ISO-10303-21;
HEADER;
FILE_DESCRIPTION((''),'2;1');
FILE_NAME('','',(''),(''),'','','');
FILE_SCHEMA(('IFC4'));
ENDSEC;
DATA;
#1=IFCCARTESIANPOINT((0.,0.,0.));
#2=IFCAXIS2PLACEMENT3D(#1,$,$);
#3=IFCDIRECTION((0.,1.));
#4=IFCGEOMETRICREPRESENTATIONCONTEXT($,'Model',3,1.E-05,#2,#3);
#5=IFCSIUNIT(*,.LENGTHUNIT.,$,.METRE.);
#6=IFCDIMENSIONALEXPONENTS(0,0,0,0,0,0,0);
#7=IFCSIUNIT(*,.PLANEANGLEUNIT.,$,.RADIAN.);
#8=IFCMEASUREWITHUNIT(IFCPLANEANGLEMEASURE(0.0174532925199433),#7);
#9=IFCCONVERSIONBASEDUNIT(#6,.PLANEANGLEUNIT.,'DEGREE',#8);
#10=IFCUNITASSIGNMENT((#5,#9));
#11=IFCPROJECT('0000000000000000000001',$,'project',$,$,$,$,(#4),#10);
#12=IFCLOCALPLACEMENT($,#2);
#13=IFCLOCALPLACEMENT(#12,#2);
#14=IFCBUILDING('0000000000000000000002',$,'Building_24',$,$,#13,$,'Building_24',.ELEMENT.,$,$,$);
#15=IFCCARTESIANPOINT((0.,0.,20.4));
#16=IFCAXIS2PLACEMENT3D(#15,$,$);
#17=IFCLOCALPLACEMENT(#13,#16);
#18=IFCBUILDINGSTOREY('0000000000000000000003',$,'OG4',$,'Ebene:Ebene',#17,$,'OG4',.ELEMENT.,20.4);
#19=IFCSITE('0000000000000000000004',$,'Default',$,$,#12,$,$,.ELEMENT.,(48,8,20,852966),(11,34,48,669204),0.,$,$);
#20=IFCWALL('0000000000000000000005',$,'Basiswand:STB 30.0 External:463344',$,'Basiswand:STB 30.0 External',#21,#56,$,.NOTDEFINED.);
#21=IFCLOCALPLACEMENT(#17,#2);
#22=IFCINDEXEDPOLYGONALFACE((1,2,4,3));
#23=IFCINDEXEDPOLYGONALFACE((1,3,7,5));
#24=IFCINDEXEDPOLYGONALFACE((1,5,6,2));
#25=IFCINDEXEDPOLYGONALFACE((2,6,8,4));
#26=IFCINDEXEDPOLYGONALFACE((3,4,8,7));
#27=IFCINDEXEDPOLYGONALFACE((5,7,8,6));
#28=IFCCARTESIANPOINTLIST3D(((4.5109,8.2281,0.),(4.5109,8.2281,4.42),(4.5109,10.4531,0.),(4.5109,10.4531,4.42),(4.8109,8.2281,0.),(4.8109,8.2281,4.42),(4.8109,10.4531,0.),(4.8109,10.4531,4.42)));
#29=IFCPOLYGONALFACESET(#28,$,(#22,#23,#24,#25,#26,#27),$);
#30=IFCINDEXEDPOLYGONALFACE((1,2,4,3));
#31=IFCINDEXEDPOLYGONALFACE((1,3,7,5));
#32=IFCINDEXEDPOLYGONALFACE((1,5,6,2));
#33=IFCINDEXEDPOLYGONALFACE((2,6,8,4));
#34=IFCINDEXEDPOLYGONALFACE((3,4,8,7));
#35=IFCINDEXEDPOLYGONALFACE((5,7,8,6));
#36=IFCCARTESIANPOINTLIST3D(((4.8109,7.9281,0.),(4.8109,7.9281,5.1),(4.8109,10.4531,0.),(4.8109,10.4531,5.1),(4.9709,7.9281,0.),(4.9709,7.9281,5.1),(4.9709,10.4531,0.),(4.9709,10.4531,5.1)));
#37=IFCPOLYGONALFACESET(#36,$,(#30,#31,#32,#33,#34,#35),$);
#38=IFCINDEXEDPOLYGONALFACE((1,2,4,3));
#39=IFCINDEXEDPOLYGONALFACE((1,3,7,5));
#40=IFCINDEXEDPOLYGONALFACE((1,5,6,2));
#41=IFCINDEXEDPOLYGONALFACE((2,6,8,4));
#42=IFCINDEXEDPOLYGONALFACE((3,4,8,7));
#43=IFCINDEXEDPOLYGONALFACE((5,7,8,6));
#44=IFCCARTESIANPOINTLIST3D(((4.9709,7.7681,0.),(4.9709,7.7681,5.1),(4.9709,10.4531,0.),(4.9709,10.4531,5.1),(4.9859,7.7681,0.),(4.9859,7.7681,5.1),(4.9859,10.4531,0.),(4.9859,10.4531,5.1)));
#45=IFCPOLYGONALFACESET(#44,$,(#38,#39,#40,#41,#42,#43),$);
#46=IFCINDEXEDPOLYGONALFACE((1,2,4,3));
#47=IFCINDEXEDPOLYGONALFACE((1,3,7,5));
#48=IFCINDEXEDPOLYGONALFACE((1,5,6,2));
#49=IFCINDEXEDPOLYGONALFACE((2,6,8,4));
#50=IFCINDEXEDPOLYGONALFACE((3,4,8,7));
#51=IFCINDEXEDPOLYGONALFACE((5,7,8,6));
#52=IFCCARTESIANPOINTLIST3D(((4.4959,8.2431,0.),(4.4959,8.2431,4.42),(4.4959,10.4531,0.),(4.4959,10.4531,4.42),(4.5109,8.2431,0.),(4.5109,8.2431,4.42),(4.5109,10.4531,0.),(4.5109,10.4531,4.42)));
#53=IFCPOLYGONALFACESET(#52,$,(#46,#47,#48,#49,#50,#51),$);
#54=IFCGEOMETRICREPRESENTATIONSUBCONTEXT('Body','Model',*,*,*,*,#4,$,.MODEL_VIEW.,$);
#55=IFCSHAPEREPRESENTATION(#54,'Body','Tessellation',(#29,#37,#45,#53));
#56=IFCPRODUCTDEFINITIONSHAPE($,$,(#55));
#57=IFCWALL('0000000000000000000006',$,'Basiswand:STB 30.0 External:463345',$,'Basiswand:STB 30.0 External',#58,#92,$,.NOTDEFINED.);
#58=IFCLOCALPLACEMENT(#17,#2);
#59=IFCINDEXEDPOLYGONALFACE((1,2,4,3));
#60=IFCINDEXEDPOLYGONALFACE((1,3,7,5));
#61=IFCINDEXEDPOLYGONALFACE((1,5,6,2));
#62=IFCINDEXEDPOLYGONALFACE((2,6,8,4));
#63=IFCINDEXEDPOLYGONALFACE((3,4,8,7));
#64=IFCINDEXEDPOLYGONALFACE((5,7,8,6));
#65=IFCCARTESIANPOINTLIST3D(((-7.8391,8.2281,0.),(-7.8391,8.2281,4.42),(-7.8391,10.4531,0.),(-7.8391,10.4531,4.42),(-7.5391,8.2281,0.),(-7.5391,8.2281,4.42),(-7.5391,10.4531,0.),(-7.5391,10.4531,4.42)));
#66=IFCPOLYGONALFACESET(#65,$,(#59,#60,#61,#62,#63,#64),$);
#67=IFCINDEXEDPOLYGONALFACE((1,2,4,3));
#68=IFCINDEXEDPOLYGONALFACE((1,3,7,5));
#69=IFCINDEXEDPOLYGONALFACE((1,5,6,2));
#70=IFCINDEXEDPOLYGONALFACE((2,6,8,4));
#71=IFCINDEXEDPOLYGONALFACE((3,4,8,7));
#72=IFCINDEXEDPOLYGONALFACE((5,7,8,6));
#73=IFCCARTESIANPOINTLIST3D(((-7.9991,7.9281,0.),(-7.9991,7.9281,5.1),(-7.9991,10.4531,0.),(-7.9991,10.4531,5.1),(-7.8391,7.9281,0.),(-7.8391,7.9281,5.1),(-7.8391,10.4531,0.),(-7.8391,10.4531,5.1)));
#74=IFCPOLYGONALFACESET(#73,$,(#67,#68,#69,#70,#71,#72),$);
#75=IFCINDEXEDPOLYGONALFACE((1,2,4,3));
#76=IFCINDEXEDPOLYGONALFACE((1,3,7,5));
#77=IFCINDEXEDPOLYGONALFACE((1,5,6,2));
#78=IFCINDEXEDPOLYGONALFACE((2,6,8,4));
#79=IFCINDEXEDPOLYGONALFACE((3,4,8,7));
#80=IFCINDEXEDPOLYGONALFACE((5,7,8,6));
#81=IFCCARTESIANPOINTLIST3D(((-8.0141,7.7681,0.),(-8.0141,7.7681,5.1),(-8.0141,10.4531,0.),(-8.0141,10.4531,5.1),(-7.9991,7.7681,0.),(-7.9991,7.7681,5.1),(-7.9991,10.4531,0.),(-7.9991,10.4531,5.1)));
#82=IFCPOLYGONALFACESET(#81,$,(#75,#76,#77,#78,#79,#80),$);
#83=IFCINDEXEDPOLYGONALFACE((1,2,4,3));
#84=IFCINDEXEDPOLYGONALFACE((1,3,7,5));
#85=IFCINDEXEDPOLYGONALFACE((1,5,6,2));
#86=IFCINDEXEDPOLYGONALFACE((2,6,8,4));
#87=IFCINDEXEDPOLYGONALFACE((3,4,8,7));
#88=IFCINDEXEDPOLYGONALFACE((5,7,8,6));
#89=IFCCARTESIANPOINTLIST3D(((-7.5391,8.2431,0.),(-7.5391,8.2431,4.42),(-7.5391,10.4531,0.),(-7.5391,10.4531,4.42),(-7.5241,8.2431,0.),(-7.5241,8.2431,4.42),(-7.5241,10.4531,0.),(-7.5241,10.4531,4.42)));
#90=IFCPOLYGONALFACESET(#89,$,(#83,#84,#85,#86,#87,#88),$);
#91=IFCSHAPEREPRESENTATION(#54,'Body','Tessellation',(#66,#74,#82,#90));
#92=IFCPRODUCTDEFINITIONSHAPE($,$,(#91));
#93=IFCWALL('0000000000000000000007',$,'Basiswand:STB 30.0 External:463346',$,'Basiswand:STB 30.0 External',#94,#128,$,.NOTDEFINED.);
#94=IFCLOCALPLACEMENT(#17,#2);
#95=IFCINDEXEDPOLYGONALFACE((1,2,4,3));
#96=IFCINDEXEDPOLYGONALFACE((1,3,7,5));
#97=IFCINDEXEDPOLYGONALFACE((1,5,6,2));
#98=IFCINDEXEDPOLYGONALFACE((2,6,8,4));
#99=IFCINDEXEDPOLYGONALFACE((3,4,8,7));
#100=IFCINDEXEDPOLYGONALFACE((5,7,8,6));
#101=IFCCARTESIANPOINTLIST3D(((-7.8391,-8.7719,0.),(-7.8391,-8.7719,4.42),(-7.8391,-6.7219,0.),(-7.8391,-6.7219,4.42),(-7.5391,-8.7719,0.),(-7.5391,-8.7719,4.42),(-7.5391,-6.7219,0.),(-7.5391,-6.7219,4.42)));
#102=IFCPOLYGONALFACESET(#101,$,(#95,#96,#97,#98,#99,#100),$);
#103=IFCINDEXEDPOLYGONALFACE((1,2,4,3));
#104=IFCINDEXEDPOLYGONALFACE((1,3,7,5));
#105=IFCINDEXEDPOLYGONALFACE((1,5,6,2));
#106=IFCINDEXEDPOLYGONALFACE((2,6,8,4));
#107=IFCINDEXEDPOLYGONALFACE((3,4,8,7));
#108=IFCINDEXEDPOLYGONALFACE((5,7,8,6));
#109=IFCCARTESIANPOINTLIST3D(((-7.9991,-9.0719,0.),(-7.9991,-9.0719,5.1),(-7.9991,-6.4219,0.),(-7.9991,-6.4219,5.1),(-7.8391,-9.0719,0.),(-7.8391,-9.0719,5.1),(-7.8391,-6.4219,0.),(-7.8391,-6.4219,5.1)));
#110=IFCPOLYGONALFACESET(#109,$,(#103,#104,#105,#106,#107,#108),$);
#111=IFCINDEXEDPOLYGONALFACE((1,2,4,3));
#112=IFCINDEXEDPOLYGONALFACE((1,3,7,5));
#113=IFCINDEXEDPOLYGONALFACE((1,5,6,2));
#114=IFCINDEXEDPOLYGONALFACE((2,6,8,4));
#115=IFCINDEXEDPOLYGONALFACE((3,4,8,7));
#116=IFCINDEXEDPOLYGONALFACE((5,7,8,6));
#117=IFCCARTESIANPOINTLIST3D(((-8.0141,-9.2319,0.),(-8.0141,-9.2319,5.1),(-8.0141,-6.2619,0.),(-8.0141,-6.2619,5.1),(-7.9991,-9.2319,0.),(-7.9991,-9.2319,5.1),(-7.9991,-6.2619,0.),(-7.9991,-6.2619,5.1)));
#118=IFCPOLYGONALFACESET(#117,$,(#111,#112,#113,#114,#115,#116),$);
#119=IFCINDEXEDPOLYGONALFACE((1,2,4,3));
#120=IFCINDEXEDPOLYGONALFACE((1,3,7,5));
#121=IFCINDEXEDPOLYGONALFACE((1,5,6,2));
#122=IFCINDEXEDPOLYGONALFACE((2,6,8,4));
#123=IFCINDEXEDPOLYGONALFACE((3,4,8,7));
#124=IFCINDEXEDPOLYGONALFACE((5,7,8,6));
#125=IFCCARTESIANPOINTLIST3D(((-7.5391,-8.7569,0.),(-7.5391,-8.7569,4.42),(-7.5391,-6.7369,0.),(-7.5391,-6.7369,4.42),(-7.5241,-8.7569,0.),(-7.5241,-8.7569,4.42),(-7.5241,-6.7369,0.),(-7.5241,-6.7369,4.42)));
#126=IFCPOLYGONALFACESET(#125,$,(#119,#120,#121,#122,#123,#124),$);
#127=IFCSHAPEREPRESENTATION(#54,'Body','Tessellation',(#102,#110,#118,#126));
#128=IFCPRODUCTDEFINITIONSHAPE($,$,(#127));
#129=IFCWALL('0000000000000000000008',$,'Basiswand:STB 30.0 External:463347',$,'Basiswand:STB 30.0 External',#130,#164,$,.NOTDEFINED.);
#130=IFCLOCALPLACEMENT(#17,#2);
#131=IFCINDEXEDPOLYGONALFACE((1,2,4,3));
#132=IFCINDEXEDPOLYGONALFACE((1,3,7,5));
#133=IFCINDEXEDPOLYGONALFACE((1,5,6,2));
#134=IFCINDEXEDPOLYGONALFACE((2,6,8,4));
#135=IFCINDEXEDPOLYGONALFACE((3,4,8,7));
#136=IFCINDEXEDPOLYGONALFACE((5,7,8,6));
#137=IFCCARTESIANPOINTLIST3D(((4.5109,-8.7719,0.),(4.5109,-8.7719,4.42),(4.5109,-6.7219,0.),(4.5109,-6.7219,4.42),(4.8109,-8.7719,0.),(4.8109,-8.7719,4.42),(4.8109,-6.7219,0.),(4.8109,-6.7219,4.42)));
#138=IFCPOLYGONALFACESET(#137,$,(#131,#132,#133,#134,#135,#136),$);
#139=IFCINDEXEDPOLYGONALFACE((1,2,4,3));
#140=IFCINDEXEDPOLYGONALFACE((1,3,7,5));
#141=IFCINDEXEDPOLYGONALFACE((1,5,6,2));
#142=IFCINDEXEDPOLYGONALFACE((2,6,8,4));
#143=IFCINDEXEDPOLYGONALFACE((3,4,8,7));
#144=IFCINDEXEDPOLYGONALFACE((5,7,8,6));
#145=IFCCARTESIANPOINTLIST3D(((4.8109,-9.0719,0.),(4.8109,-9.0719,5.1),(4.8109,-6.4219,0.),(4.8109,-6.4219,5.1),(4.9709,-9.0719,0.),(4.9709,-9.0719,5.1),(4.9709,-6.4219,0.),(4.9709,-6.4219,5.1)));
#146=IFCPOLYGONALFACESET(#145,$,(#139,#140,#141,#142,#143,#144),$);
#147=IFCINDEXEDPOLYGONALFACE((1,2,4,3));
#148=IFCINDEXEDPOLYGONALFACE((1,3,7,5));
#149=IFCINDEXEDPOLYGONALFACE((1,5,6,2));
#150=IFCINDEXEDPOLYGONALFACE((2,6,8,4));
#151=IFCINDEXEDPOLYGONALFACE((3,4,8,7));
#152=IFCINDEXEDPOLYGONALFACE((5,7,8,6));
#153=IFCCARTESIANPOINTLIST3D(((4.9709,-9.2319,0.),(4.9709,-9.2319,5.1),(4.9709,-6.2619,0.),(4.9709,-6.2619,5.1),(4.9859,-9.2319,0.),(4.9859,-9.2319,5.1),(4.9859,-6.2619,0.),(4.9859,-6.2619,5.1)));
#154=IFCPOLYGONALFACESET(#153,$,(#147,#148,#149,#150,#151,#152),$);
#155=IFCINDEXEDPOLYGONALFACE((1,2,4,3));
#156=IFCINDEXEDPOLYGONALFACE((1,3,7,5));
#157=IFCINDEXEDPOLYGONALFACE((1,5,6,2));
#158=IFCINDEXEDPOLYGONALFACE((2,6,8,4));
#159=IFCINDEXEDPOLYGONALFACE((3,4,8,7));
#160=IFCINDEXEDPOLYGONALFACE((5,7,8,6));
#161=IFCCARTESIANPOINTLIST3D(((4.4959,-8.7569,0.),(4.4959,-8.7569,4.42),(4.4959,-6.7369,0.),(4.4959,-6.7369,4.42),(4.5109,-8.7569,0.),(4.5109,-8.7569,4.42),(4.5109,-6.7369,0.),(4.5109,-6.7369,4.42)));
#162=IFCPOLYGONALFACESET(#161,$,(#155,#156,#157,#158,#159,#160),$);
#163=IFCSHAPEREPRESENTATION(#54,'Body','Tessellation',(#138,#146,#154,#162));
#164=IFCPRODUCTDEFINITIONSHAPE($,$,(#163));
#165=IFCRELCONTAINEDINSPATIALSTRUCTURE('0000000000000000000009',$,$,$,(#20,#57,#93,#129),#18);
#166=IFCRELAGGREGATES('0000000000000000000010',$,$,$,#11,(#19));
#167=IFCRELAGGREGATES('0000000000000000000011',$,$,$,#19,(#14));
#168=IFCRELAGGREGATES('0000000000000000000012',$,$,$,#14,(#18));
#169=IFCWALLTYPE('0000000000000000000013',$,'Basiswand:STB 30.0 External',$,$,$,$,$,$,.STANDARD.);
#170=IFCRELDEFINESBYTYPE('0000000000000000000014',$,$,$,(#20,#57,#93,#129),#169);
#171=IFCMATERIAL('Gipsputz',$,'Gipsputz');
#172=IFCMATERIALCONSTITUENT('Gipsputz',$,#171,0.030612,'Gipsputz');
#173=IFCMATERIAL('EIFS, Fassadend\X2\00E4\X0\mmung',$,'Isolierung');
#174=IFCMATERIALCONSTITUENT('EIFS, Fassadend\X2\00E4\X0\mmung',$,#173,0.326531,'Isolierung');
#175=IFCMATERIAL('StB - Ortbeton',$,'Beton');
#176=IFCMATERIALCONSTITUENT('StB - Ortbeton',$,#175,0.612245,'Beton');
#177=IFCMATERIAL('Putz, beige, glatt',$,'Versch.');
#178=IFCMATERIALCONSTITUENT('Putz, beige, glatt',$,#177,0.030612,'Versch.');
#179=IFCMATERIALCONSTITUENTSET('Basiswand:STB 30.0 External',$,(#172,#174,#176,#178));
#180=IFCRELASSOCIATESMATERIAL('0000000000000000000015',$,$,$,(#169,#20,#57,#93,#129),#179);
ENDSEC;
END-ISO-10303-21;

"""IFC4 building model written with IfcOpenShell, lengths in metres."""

from ifc_helpers import new_model, entity, si_unit, converted_unit, direction, frame, origin, place, context, subcontext, project, spatial, indexed_curve, outline, extrude, material, constituent, constituent_set, type_object, element, save


model = new_model("IFC4")

# Units and contexts
model_context = context("Model", 3, precision=1e-05, world=origin(), true_north=direction((0.0, 1.0)))
body_context = subcontext(model_context, "Body", "Model", "MODEL_VIEW")
ifc_project = project(units=[si_unit("LENGTHUNIT", "METRE"), converted_unit("PLANEANGLEUNIT", "DEGREE", entity("IfcPlaneAngleMeasure", 0.0174532925199433), si_unit("PLANEANGLEUNIT", "RADIAN"), dimensions=[0, 0, 0, 0, 0, 0, 0])], contexts=[model_context])

# Site, building, storey
site_placement = place(None, origin())
site = spatial("IfcSite", under=ifc_project, at=site_placement, Name="Default", CompositionType="ELEMENT", RefLatitude=(48, 8, 20, 852966), RefLongitude=(11, 34, 48, 669204), RefElevation=0.0)
building_placement = place(site_placement, origin())
building = spatial("IfcBuilding", under=site, at=building_placement, Name="Building_24", LongName="Building_24", CompositionType="ELEMENT")
storey_placement = place(building_placement, frame((0.0, 0.0, 20.4)))
storey = spatial("IfcBuildingStorey", under=building, at=storey_placement, Name="OG4", ObjectType="Ebene:Ebene", LongName="OG4", CompositionType="ELEMENT", Elevation=20.4)

# Shared definitions
ifc_material_1 = material(Name="StB - Ortbeton", Category="Beton")

# Walls
ifc_material_2 = material(Name="Gipsputz", Category="Gipsputz")
ifc_constituent_1 = constituent(ifc_material_2, Name="Gipsputz", Category="Gipsputz", fraction=0.030612)
ifc_material_3 = material(Name="EIFS, Fassadendämmung", Category="Isolierung")
ifc_constituent_2 = constituent(ifc_material_3, Name="EIFS, Fassadendämmung", Category="Isolierung", fraction=0.326531)
ifc_constituent_3 = constituent(ifc_material_1, Name="StB - Ortbeton", Category="Beton", fraction=0.612245)
ifc_material_4 = material(Name="Putz, beige, glatt", Category="Versch.")
ifc_constituent_4 = constituent(ifc_material_4, Name="Putz, beige, glatt", Category="Versch.", fraction=0.030612)
ifc_constituent_set_1 = constituent_set(constituents=[ifc_constituent_1, ifc_constituent_2, ifc_constituent_3, ifc_constituent_4], Name="Basiswand:STB 30.0 External")
wall_type_1 = type_object("IfcWallType", Name="Basiswand:STB 30.0 External", PredefinedType="STANDARD", material=ifc_constituent_set_1)
wall_1_placement = place(storey_placement, frame((4.7409, 10.4531, 0.0), z_axis=(0.0, 0.0, 1.0), x_axis=(0.0, -1.0, 0.0)))
element("IfcWall", 1, at=wall_1_placement, inside=storey, type_object=wall_type_1, material=ifc_constituent_set_1, Name="Basiswand:STB 30.0 External:463344", ObjectType="Basiswand:STB 30.0 External", PredefinedType="NOTDEFINED", context=body_context, shape_type="SweptSolid", body=[
    extrude(outline(indexed_curve([(-2.21, -1.1125), (2.21, -1.1125), (2.21, 1.1125), (-2.21, 1.1125), (-2.21, -1.1125)], self_intersect=False)), frame((1.1125, -0.23, 2.21), z_axis=(0.0, 1.0, 0.0), x_axis=(0.0, 0.0, 1.0)), (0.0, 0.0, 1.0), 0.3),
    extrude(outline(indexed_curve([(-1.2625, -0.08), (1.2625, -0.08), (1.2625, 0.08), (-1.2625, 0.08), (-1.2625, -0.08)], self_intersect=False)), frame((1.2625, 0.15, 0.0)), (0.0, 0.0, 1.0), 5.1),
    extrude(outline(indexed_curve([(-0.0075, -1.3425), (0.0075, -1.3425), (0.0075, 1.3425), (-0.0075, 1.3425), (-0.0075, -1.3425)], self_intersect=False)), frame((1.3425, 0.2375, 0.0), z_axis=(0.0, 0.0, 1.0), x_axis=(0.0, -1.0, 0.0)), (0.0, 0.0, 1.0), 5.1),
    extrude(outline(indexed_curve([(-2.21, -1.105), (2.21, -1.105), (2.21, 1.105), (-2.21, 1.105), (-2.21, -1.105)], self_intersect=False)), frame((1.105, -0.245, 2.21), z_axis=(0.0, 1.0, 0.0), x_axis=(0.0, 0.0, 1.0)), (0.0, 0.0, 1.0), 0.015),
])
wall_2_placement = place(storey_placement, frame((-7.7691, 10.4531, 0.0), z_axis=(0.0, 0.0, 1.0), x_axis=(0.0, -1.0, 0.0)))
element("IfcWall", 2, at=wall_2_placement, inside=storey, type_object=wall_type_1, material=ifc_constituent_set_1, Name="Basiswand:STB 30.0 External:463345", ObjectType="Basiswand:STB 30.0 External", PredefinedType="NOTDEFINED", context=body_context, shape_type="SweptSolid", body=[
    extrude(outline(indexed_curve([(-2.21, -1.1125), (2.21, -1.1125), (2.21, 1.1125), (-2.21, 1.1125), (-2.21, -1.1125)], self_intersect=False)), frame((1.1125, -0.07, 2.21), z_axis=(0.0, 1.0, 0.0), x_axis=(0.0, 0.0, 1.0)), (0.0, 0.0, 1.0), 0.3),
    extrude(outline(indexed_curve([(-1.2625, -0.08), (1.2625, -0.08), (1.2625, 0.08), (-1.2625, 0.08), (-1.2625, -0.08)], self_intersect=False)), frame((1.2625, -0.15, 0.0)), (0.0, 0.0, 1.0), 5.1),
    extrude(outline(indexed_curve([(-0.0075, -1.3425), (0.0075, -1.3425), (0.0075, 1.3425), (-0.0075, 1.3425), (-0.0075, -1.3425)], self_intersect=False)), frame((1.3425, -0.2375, 0.0), z_axis=(0.0, 0.0, 1.0), x_axis=(0.0, 1.0, 0.0)), (0.0, 0.0, 1.0), 5.1),
    extrude(outline(indexed_curve([(-2.21, -1.105), (2.21, -1.105), (2.21, 1.105), (-2.21, 1.105), (-2.21, -1.105)], self_intersect=False)), frame((1.105, 0.23, 2.21), z_axis=(0.0, 1.0, 0.0), x_axis=(0.0, 0.0, 1.0)), (0.0, 0.0, 1.0), 0.015),
])
wall_3_placement = place(storey_placement, frame((-7.7691, -6.7369, 0.0), z_axis=(0.0, 0.0, 1.0), x_axis=(0.0, -1.0, 0.0)))
element("IfcWall", 3, at=wall_3_placement, inside=storey, type_object=wall_type_1, material=ifc_constituent_set_1, Name="Basiswand:STB 30.0 External:463346", ObjectType="Basiswand:STB 30.0 External", PredefinedType="NOTDEFINED", context=body_context, shape_type="SweptSolid", body=[
    extrude(outline(indexed_curve([(-2.21, -1.025), (2.21, -1.025), (2.21, 1.025), (-2.21, 1.025), (-2.21, -1.025)], self_intersect=False)), frame((1.01, -0.07, 2.21), z_axis=(0.0, 1.0, 0.0), x_axis=(0.0, 0.0, 1.0)), (0.0, 0.0, 1.0), 0.3),
    extrude(outline(indexed_curve([(-1.325, -0.08), (1.325, -0.08), (1.325, 0.08), (-1.325, 0.08), (-1.325, -0.08)], self_intersect=False)), frame((1.01, -0.15, 0.0)), (0.0, 0.0, 1.0), 5.1),
    extrude(outline(indexed_curve([(-0.0075, -1.485), (0.0075, -1.485), (0.0075, 1.485), (-0.0075, 1.485), (-0.0075, -1.485)], self_intersect=False)), frame((1.01, -0.2375, 0.0), z_axis=(0.0, 0.0, 1.0), x_axis=(0.0, 1.0, 0.0)), (0.0, 0.0, 1.0), 5.1),
    extrude(outline(indexed_curve([(-2.21, -1.01), (2.21, -1.01), (2.21, 1.01), (-2.21, 1.01), (-2.21, -1.01)], self_intersect=False)), frame((1.01, 0.23, 2.21), z_axis=(0.0, 1.0, 0.0), x_axis=(0.0, 0.0, 1.0)), (0.0, 0.0, 1.0), 0.015),
])
wall_4_placement = place(storey_placement, frame((4.7409, -6.7369, 0.0), z_axis=(0.0, 0.0, 1.0), x_axis=(0.0, -1.0, 0.0)))
element("IfcWall", 4, at=wall_4_placement, inside=storey, type_object=wall_type_1, material=ifc_constituent_set_1, Name="Basiswand:STB 30.0 External:463347", ObjectType="Basiswand:STB 30.0 External", PredefinedType="NOTDEFINED", context=body_context, shape_type="SweptSolid", body=[
    extrude(outline(indexed_curve([(-2.21, -1.025), (2.21, -1.025), (2.21, 1.025), (-2.21, 1.025), (-2.21, -1.025)], self_intersect=False)), frame((1.01, -0.23, 2.21), z_axis=(0.0, 1.0, 0.0), x_axis=(0.0, 0.0, 1.0)), (0.0, 0.0, 1.0), 0.3),
    extrude(outline(indexed_curve([(-1.325, -0.08), (1.325, -0.08), (1.325, 0.08), (-1.325, 0.08), (-1.325, -0.08)], self_intersect=False)), frame((1.01, 0.15, 0.0)), (0.0, 0.0, 1.0), 5.1),
    extrude(outline(indexed_curve([(-0.0075, -1.485), (0.0075, -1.485), (0.0075, 1.485), (-0.0075, 1.485), (-0.0075, -1.485)], self_intersect=False)), frame((1.01, 0.2375, 0.0), z_axis=(0.0, 0.0, 1.0), x_axis=(0.0, -1.0, 0.0)), (0.0, 0.0, 1.0), 5.1),
    extrude(outline(indexed_curve([(-2.21, -1.01), (2.21, -1.01), (2.21, 1.01), (-2.21, 1.01), (-2.21, -1.01)], self_intersect=False)), frame((1.01, -0.245, 2.21), z_axis=(0.0, 1.0, 0.0), x_axis=(0.0, 0.0, 1.0)), (0.0, 0.0, 1.0), 0.015),
])

save(model, "model.ifc")
